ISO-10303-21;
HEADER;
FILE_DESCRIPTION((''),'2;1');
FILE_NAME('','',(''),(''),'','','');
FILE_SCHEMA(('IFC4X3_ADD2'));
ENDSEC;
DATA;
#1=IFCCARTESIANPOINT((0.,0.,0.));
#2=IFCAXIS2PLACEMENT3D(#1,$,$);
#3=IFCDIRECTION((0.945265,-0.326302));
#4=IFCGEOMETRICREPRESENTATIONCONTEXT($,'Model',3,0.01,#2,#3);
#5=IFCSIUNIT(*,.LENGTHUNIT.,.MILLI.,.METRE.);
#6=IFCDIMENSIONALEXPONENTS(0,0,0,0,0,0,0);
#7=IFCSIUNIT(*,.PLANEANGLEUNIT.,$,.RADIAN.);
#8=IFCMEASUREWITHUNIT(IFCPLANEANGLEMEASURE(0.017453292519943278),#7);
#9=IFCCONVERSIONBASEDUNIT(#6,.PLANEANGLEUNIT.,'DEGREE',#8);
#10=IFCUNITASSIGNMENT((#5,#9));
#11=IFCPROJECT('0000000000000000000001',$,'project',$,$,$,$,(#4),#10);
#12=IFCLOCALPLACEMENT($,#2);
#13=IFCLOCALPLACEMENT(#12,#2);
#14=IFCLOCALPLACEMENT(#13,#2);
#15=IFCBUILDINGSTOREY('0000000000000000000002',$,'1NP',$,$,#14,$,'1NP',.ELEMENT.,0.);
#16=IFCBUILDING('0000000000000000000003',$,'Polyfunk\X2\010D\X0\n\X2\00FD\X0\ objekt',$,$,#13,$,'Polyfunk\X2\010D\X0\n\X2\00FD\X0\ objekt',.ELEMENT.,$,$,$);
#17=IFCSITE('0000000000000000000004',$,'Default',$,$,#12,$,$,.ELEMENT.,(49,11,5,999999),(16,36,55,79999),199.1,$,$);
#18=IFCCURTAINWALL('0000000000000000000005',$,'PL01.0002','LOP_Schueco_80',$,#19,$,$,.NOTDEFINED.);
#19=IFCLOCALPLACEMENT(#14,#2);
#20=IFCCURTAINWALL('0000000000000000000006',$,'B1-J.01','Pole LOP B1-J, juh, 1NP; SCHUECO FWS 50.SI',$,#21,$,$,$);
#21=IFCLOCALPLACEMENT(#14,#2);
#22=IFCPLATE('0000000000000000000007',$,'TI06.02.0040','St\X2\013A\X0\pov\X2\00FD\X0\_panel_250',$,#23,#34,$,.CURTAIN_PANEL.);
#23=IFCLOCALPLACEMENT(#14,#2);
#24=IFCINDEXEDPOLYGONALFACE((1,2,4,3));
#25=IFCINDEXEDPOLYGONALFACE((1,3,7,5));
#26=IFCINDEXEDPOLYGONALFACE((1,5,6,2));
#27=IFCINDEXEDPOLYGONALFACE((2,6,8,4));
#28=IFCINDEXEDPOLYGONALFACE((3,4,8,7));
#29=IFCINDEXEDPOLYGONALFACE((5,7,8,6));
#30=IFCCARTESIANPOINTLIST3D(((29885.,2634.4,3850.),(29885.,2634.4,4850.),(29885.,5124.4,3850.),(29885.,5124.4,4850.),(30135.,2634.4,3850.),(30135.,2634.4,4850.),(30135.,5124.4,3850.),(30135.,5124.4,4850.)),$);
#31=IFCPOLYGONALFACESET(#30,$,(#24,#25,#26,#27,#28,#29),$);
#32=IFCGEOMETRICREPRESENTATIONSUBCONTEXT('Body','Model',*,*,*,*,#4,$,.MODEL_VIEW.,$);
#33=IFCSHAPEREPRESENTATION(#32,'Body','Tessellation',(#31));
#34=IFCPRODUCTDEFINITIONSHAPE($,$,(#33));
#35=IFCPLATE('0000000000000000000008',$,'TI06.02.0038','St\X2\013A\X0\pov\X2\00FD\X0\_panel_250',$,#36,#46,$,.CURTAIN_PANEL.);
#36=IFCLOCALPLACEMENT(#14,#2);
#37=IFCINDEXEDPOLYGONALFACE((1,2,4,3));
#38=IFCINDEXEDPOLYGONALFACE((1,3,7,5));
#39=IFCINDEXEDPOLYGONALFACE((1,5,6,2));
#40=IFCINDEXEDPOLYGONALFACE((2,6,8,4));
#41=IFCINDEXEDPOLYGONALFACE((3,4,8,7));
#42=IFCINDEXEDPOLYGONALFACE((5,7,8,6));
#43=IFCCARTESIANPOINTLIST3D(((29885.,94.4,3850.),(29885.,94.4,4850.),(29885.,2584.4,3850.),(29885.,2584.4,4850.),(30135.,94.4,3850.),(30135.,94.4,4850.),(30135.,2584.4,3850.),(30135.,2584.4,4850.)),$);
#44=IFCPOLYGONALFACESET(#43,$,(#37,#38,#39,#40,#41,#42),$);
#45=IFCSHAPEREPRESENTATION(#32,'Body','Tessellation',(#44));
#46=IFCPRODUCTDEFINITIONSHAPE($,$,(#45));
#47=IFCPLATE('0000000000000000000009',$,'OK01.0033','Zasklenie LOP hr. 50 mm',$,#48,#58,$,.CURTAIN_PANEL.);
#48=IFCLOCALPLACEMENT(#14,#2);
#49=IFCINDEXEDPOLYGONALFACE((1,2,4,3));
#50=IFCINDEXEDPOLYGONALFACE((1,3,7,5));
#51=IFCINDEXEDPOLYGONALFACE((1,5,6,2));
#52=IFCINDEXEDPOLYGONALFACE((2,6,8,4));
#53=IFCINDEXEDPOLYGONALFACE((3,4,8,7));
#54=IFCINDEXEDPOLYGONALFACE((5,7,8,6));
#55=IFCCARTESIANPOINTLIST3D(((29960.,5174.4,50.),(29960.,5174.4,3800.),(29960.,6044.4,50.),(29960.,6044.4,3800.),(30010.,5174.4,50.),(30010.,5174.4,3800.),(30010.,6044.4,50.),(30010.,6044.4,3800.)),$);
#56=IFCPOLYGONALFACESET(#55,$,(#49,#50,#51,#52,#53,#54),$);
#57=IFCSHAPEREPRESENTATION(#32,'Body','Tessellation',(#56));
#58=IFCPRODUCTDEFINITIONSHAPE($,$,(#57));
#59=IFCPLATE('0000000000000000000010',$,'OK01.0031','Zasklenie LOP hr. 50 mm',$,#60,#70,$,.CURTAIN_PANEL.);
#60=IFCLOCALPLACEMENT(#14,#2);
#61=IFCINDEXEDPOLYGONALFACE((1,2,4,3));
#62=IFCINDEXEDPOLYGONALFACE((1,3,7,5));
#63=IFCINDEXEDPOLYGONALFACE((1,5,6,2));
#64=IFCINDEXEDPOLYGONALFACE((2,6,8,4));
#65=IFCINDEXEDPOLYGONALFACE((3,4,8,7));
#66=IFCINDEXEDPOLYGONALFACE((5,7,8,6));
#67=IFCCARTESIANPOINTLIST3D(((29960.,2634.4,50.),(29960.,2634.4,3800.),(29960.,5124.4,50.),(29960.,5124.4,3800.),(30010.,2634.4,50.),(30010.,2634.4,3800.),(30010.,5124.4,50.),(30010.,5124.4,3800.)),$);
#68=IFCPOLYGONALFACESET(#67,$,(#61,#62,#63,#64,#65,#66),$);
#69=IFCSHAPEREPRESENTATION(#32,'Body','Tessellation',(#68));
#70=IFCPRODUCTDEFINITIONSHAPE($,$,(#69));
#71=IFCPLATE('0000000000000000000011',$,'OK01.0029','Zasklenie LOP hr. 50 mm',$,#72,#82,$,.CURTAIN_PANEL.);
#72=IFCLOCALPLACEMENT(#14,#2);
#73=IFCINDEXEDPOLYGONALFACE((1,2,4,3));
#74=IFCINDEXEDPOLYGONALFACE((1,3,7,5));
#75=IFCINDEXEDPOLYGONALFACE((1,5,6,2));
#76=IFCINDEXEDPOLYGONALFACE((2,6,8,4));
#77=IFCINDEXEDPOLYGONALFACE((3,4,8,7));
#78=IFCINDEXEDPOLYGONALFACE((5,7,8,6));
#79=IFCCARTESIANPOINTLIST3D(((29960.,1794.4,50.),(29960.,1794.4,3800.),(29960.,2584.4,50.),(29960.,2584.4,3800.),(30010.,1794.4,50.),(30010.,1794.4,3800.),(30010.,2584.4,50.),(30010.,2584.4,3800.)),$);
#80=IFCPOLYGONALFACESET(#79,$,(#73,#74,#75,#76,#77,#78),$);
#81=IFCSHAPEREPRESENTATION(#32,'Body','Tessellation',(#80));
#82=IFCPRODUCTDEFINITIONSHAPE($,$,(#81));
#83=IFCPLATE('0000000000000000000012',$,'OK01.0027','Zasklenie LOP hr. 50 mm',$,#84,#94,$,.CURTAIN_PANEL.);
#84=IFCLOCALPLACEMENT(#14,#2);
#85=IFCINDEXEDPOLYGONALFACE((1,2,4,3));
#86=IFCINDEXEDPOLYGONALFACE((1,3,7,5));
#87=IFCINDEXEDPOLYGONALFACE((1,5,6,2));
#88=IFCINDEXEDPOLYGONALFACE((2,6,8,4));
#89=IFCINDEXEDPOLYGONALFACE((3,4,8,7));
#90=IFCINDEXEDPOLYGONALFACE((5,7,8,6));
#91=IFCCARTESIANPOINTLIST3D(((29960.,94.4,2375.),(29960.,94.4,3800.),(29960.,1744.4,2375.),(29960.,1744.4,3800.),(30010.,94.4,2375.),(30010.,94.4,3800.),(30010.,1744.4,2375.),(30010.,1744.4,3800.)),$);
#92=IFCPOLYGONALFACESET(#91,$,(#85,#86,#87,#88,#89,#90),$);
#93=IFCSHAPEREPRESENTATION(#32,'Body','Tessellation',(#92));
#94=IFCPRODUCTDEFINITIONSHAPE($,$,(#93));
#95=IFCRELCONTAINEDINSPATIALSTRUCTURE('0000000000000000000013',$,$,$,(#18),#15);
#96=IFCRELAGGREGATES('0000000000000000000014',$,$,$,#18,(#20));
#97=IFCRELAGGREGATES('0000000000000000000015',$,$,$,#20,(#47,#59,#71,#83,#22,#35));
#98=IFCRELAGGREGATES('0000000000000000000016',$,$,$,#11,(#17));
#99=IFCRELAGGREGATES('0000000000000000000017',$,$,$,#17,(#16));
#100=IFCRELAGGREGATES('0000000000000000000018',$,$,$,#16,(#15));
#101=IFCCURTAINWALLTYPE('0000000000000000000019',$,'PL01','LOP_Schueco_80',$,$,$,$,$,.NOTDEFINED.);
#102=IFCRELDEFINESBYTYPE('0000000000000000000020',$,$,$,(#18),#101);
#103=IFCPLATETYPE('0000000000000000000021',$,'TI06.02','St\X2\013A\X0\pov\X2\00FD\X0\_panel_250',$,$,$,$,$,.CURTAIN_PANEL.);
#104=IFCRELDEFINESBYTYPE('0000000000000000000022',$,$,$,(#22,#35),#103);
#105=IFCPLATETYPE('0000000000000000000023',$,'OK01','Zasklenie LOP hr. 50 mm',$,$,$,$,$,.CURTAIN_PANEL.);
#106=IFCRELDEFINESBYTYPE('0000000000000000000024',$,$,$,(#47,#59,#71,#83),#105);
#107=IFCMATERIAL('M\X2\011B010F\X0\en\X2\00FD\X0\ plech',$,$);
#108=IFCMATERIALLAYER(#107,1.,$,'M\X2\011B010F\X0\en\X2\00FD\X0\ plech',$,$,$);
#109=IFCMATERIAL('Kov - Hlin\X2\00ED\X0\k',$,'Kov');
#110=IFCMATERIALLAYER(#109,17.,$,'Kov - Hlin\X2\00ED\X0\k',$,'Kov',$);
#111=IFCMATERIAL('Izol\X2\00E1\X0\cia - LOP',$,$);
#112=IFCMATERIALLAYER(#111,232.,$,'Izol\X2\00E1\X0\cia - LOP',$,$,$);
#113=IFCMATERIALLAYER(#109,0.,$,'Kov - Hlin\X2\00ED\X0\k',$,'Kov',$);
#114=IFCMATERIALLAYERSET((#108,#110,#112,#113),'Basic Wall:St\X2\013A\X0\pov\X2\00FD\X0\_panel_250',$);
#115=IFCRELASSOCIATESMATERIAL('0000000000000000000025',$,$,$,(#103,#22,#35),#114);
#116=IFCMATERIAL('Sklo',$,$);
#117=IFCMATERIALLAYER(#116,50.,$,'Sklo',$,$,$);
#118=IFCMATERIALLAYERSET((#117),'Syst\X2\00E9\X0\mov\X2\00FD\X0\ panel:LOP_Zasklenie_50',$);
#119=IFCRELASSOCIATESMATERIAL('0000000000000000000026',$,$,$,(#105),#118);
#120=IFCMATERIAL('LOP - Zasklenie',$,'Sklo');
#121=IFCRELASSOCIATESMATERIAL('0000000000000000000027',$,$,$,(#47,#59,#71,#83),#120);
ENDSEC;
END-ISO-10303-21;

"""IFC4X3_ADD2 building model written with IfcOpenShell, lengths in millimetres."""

from ifc_helpers import new_model, entity, si_unit, converted_unit, direction, frame, frame_2d, origin, origin_2d_with_axis, place, context, subcontext, project, spatial, rectangle, extrude, source, transform, mapped, material, layer, layer_set, layer_usage, type_object, type_shapes, element, aggregate, save


model = new_model("IFC4X3_ADD2")

# Units and contexts
model_context = context("Model", 3, precision=0.01, world=origin(), true_north=direction((0.945265, -0.326302)))
body_context = subcontext(model_context, "Body", "Model", "MODEL_VIEW")
ifc_project = project(units=[si_unit("LENGTHUNIT", "METRE", prefix="MILLI"), converted_unit("PLANEANGLEUNIT", "DEGREE", entity("IfcPlaneAngleMeasure", 0.017453292519943278), si_unit("PLANEANGLEUNIT", "RADIAN"), dimensions=[0, 0, 0, 0, 0, 0, 0])], contexts=[model_context])

# Site, building, storey
site_placement = place(None, origin())
site = spatial("IfcSite", under=ifc_project, at=site_placement, Name="Default", CompositionType="ELEMENT", RefLatitude=(49, 11, 5, 999999), RefLongitude=(16, 36, 55, 79999), RefElevation=199.1)
building_placement = place(site_placement, origin())
building = spatial("IfcBuilding", under=site, at=building_placement, Name="Polyfunkčný objekt", LongName="Polyfunkčný objekt", CompositionType="ELEMENT")
storey_placement = place(building_placement, origin())
storey = spatial("IfcBuildingStorey", under=building, at=storey_placement, Name="1NP", LongName="1NP", CompositionType="ELEMENT", Elevation=0.0)

# Curtain walls, plates
curtain_wall_type = type_object("IfcCurtainWallType", Name="PL01", Description="LOP_Schueco_80", PredefinedType="NOTDEFINED")
curtain_wall_1_placement = place(storey_placement, origin())
curtain_wall_1 = element("IfcCurtainWall", 1, at=curtain_wall_1_placement, inside=storey, type_object=curtain_wall_type, Name="PL01.0002", Description="LOP_Schueco_80", PredefinedType="NOTDEFINED")
curtain_wall_2 = element("IfcCurtainWall", 2, Name="B1-J.01", Description="Pole LOP B1-J, juh, 1NP; SCHUECO FWS 50.SI")
aggregate(curtain_wall_1, [curtain_wall_2])
ifc_material_1 = material(Name="Měďený plech")
ifc_layer_1 = layer(ifc_material_1, 1.0, Name="Měďený plech")
ifc_material_2 = material(Name="Kov - Hliník", Category="Kov")
ifc_layer_2 = layer(ifc_material_2, 17.0, Name="Kov - Hliník", Category="Kov")
ifc_material_3 = material(Name="Izolácia - LOP")
ifc_layer_3 = layer(ifc_material_3, 232.0, Name="Izolácia - LOP")
ifc_layer_4 = layer(ifc_material_2, 0.0, Name="Kov - Hliník", Category="Kov")
ifc_layer_set_1 = layer_set([ifc_layer_1, ifc_layer_2, ifc_layer_3, ifc_layer_4], Name="Basic Wall:Stĺpový_panel_250")
ifc_layer_usage_1 = layer_usage(ifc_layer_set_1, "AXIS2", "POSITIVE", -125.0)
plate_type_1 = type_object("IfcPlateType", Name="TI06.02", Description="Stĺpový_panel_250", PredefinedType="CURTAIN_PANEL", material=ifc_layer_set_1)
plate_1_placement = place(storey_placement, frame((30010.0, 5124.4, 3850.0), z_axis=(0.0, 0.0, 1.0), x_axis=(0.0, -1.0, 0.0)))
plate_1 = element("IfcPlate", 3, at=plate_1_placement, type_object=plate_type_1, material=ifc_layer_usage_1, Name="TI06.02.0040", Description="Stĺpový_panel_250", PredefinedType="CURTAIN_PANEL", context=body_context, shape_type="SweptSolid", body=[
    extrude(rectangle(XDim=250.0, YDim=2490.0, at=frame_2d((0.0, 0.0), x_axis=(1.0, 0.0))), frame((1245.0, 0.0, 0.0), z_axis=(0.0, 0.0, 1.0), x_axis=(0.0, 1.0, 0.0)), (0.0, 0.0, 1.0), 1000.0),
])
ifc_layer_usage_2 = layer_usage(ifc_layer_set_1, "AXIS2", "POSITIVE", -125.0)
plate_2_placement = place(storey_placement, frame((30010.0, 2584.4, 3850.0), z_axis=(0.0, 0.0, 1.0), x_axis=(0.0, -1.0, 0.0)))
plate_2 = element("IfcPlate", 4, at=plate_2_placement, type_object=plate_type_1, material=ifc_layer_usage_2, Name="TI06.02.0038", Description="Stĺpový_panel_250", PredefinedType="CURTAIN_PANEL", context=body_context, shape_type="SweptSolid", body=[
    extrude(rectangle(XDim=250.0, YDim=2490.0, at=frame_2d((0.0, 0.0), x_axis=(1.0, 0.0))), frame((1245.0, 0.0, 0.0), z_axis=(0.0, 0.0, 1.0), x_axis=(0.0, 1.0, 0.0)), (0.0, 0.0, 1.0), 1000.0),
])
ifc_material_4 = material(Name="LOP - Zasklenie", Category="Sklo")
ifc_material_5 = material(Name="Sklo")
ifc_layer_5 = layer(ifc_material_5, 50.0, Name="Sklo")
ifc_layer_set_2 = layer_set([ifc_layer_5], Name="Systémový panel:LOP_Zasklenie_50")
plate_type_2 = type_object("IfcPlateType", Name="OK01", Description="Zasklenie LOP hr. 50 mm", PredefinedType="CURTAIN_PANEL", material=ifc_layer_set_2)
shared_shape_1 = source(origin(), body_context, "Body", "SweptSolid", [
    extrude(rectangle(XDim=3750.0, YDim=870.0, at=frame_2d((-141.7, 0.0), x_axis=(1.0, 0.0))), frame((0.0, -50.0, 2016.7), z_axis=(0.0, 1.0, 0.0), x_axis=(0.0, 0.0, 1.0)), (0.0, 0.0, 1.0), 50.0),
])
plate_3_placement = place(curtain_wall_1_placement, frame((30010.0, 5609.4, 50.0), z_axis=(0.0, 0.0, 1.0), x_axis=(0.0, -1.0, 0.0)))
plate_3 = element("IfcPlate", 5, at=plate_3_placement, type_object=plate_type_2, material=ifc_material_4, Name="OK01.0033", Description="Zasklenie LOP hr. 50 mm", PredefinedType="CURTAIN_PANEL", context=body_context, shape_type="MappedRepresentation", body=[
    mapped(shared_shape_1, transform((0.0, 0.0, 0.0), scale=1.0)),
])
shared_shape_2 = source(origin(), body_context, "Body", "SweptSolid", [
    extrude(rectangle(XDim=3750.0, YDim=2490.0, at=frame_2d((-141.7, 0.0), x_axis=(1.0, 0.0))), frame((0.0, -50.0, 2016.7), z_axis=(0.0, 1.0, 0.0), x_axis=(0.0, 0.0, 1.0)), (0.0, 0.0, 1.0), 50.0),
])
plate_4_placement = place(curtain_wall_1_placement, frame((30010.0, 3879.4, 50.0), z_axis=(0.0, 0.0, 1.0), x_axis=(0.0, -1.0, 0.0)))
plate_4 = element("IfcPlate", 6, at=plate_4_placement, type_object=plate_type_2, material=ifc_material_4, Name="OK01.0031", Description="Zasklenie LOP hr. 50 mm", PredefinedType="CURTAIN_PANEL", context=body_context, shape_type="MappedRepresentation", body=[
    mapped(shared_shape_2, transform((0.0, 0.0, 0.0), scale=1.0)),
])
shared_shape_3 = source(origin(), body_context, "Body", "SweptSolid", [
    extrude(rectangle(XDim=3750.0, YDim=790.0, at=frame_2d((-141.7, 0.0), x_axis=(1.0, 0.0))), frame((0.0, -50.0, 2016.7), z_axis=(0.0, 1.0, 0.0), x_axis=(0.0, 0.0, 1.0)), (0.0, 0.0, 1.0), 50.0),
])
plate_5_placement = place(curtain_wall_1_placement, frame((30010.0, 2189.4, 50.0), z_axis=(0.0, 0.0, 1.0), x_axis=(0.0, -1.0, 0.0)))
plate_5 = element("IfcPlate", 7, at=plate_5_placement, type_object=plate_type_2, material=ifc_material_4, Name="OK01.0029", Description="Zasklenie LOP hr. 50 mm", PredefinedType="CURTAIN_PANEL", context=body_context, shape_type="MappedRepresentation", body=[
    mapped(shared_shape_3, transform((0.0, 0.0, 0.0), scale=1.0)),
])
shared_shape_4 = source(origin(), body_context, "Body", "SweptSolid", [
    extrude(rectangle(XDim=50.0, YDim=1650.0, at=origin_2d_with_axis()), frame((0.0, -25.0, 0.0), z_axis=(0.0, 0.0, 1.0), x_axis=(0.0, 1.0, 0.0)), (0.0, 0.0, 1.0), 1425.0),
])
type_shapes(plate_type_2, [shared_shape_1, shared_shape_2, shared_shape_3, shared_shape_4])
plate_6_placement = place(curtain_wall_1_placement, frame((30010.0, 919.4, 2375.0), z_axis=(0.0, 0.0, 1.0), x_axis=(0.0, -1.0, 0.0)))
plate_6 = element("IfcPlate", 8, at=plate_6_placement, type_object=plate_type_2, material=ifc_material_4, Name="OK01.0027", Description="Zasklenie LOP hr. 50 mm", PredefinedType="CURTAIN_PANEL", context=body_context, shape_type="MappedRepresentation", body=[
    mapped(shared_shape_4, transform((0.0, 0.0, 0.0), scale=1.0)),
])
aggregate(curtain_wall_2, [plate_3, plate_4, plate_5, plate_6, plate_1, plate_2])

save(model, "model.ifc")
